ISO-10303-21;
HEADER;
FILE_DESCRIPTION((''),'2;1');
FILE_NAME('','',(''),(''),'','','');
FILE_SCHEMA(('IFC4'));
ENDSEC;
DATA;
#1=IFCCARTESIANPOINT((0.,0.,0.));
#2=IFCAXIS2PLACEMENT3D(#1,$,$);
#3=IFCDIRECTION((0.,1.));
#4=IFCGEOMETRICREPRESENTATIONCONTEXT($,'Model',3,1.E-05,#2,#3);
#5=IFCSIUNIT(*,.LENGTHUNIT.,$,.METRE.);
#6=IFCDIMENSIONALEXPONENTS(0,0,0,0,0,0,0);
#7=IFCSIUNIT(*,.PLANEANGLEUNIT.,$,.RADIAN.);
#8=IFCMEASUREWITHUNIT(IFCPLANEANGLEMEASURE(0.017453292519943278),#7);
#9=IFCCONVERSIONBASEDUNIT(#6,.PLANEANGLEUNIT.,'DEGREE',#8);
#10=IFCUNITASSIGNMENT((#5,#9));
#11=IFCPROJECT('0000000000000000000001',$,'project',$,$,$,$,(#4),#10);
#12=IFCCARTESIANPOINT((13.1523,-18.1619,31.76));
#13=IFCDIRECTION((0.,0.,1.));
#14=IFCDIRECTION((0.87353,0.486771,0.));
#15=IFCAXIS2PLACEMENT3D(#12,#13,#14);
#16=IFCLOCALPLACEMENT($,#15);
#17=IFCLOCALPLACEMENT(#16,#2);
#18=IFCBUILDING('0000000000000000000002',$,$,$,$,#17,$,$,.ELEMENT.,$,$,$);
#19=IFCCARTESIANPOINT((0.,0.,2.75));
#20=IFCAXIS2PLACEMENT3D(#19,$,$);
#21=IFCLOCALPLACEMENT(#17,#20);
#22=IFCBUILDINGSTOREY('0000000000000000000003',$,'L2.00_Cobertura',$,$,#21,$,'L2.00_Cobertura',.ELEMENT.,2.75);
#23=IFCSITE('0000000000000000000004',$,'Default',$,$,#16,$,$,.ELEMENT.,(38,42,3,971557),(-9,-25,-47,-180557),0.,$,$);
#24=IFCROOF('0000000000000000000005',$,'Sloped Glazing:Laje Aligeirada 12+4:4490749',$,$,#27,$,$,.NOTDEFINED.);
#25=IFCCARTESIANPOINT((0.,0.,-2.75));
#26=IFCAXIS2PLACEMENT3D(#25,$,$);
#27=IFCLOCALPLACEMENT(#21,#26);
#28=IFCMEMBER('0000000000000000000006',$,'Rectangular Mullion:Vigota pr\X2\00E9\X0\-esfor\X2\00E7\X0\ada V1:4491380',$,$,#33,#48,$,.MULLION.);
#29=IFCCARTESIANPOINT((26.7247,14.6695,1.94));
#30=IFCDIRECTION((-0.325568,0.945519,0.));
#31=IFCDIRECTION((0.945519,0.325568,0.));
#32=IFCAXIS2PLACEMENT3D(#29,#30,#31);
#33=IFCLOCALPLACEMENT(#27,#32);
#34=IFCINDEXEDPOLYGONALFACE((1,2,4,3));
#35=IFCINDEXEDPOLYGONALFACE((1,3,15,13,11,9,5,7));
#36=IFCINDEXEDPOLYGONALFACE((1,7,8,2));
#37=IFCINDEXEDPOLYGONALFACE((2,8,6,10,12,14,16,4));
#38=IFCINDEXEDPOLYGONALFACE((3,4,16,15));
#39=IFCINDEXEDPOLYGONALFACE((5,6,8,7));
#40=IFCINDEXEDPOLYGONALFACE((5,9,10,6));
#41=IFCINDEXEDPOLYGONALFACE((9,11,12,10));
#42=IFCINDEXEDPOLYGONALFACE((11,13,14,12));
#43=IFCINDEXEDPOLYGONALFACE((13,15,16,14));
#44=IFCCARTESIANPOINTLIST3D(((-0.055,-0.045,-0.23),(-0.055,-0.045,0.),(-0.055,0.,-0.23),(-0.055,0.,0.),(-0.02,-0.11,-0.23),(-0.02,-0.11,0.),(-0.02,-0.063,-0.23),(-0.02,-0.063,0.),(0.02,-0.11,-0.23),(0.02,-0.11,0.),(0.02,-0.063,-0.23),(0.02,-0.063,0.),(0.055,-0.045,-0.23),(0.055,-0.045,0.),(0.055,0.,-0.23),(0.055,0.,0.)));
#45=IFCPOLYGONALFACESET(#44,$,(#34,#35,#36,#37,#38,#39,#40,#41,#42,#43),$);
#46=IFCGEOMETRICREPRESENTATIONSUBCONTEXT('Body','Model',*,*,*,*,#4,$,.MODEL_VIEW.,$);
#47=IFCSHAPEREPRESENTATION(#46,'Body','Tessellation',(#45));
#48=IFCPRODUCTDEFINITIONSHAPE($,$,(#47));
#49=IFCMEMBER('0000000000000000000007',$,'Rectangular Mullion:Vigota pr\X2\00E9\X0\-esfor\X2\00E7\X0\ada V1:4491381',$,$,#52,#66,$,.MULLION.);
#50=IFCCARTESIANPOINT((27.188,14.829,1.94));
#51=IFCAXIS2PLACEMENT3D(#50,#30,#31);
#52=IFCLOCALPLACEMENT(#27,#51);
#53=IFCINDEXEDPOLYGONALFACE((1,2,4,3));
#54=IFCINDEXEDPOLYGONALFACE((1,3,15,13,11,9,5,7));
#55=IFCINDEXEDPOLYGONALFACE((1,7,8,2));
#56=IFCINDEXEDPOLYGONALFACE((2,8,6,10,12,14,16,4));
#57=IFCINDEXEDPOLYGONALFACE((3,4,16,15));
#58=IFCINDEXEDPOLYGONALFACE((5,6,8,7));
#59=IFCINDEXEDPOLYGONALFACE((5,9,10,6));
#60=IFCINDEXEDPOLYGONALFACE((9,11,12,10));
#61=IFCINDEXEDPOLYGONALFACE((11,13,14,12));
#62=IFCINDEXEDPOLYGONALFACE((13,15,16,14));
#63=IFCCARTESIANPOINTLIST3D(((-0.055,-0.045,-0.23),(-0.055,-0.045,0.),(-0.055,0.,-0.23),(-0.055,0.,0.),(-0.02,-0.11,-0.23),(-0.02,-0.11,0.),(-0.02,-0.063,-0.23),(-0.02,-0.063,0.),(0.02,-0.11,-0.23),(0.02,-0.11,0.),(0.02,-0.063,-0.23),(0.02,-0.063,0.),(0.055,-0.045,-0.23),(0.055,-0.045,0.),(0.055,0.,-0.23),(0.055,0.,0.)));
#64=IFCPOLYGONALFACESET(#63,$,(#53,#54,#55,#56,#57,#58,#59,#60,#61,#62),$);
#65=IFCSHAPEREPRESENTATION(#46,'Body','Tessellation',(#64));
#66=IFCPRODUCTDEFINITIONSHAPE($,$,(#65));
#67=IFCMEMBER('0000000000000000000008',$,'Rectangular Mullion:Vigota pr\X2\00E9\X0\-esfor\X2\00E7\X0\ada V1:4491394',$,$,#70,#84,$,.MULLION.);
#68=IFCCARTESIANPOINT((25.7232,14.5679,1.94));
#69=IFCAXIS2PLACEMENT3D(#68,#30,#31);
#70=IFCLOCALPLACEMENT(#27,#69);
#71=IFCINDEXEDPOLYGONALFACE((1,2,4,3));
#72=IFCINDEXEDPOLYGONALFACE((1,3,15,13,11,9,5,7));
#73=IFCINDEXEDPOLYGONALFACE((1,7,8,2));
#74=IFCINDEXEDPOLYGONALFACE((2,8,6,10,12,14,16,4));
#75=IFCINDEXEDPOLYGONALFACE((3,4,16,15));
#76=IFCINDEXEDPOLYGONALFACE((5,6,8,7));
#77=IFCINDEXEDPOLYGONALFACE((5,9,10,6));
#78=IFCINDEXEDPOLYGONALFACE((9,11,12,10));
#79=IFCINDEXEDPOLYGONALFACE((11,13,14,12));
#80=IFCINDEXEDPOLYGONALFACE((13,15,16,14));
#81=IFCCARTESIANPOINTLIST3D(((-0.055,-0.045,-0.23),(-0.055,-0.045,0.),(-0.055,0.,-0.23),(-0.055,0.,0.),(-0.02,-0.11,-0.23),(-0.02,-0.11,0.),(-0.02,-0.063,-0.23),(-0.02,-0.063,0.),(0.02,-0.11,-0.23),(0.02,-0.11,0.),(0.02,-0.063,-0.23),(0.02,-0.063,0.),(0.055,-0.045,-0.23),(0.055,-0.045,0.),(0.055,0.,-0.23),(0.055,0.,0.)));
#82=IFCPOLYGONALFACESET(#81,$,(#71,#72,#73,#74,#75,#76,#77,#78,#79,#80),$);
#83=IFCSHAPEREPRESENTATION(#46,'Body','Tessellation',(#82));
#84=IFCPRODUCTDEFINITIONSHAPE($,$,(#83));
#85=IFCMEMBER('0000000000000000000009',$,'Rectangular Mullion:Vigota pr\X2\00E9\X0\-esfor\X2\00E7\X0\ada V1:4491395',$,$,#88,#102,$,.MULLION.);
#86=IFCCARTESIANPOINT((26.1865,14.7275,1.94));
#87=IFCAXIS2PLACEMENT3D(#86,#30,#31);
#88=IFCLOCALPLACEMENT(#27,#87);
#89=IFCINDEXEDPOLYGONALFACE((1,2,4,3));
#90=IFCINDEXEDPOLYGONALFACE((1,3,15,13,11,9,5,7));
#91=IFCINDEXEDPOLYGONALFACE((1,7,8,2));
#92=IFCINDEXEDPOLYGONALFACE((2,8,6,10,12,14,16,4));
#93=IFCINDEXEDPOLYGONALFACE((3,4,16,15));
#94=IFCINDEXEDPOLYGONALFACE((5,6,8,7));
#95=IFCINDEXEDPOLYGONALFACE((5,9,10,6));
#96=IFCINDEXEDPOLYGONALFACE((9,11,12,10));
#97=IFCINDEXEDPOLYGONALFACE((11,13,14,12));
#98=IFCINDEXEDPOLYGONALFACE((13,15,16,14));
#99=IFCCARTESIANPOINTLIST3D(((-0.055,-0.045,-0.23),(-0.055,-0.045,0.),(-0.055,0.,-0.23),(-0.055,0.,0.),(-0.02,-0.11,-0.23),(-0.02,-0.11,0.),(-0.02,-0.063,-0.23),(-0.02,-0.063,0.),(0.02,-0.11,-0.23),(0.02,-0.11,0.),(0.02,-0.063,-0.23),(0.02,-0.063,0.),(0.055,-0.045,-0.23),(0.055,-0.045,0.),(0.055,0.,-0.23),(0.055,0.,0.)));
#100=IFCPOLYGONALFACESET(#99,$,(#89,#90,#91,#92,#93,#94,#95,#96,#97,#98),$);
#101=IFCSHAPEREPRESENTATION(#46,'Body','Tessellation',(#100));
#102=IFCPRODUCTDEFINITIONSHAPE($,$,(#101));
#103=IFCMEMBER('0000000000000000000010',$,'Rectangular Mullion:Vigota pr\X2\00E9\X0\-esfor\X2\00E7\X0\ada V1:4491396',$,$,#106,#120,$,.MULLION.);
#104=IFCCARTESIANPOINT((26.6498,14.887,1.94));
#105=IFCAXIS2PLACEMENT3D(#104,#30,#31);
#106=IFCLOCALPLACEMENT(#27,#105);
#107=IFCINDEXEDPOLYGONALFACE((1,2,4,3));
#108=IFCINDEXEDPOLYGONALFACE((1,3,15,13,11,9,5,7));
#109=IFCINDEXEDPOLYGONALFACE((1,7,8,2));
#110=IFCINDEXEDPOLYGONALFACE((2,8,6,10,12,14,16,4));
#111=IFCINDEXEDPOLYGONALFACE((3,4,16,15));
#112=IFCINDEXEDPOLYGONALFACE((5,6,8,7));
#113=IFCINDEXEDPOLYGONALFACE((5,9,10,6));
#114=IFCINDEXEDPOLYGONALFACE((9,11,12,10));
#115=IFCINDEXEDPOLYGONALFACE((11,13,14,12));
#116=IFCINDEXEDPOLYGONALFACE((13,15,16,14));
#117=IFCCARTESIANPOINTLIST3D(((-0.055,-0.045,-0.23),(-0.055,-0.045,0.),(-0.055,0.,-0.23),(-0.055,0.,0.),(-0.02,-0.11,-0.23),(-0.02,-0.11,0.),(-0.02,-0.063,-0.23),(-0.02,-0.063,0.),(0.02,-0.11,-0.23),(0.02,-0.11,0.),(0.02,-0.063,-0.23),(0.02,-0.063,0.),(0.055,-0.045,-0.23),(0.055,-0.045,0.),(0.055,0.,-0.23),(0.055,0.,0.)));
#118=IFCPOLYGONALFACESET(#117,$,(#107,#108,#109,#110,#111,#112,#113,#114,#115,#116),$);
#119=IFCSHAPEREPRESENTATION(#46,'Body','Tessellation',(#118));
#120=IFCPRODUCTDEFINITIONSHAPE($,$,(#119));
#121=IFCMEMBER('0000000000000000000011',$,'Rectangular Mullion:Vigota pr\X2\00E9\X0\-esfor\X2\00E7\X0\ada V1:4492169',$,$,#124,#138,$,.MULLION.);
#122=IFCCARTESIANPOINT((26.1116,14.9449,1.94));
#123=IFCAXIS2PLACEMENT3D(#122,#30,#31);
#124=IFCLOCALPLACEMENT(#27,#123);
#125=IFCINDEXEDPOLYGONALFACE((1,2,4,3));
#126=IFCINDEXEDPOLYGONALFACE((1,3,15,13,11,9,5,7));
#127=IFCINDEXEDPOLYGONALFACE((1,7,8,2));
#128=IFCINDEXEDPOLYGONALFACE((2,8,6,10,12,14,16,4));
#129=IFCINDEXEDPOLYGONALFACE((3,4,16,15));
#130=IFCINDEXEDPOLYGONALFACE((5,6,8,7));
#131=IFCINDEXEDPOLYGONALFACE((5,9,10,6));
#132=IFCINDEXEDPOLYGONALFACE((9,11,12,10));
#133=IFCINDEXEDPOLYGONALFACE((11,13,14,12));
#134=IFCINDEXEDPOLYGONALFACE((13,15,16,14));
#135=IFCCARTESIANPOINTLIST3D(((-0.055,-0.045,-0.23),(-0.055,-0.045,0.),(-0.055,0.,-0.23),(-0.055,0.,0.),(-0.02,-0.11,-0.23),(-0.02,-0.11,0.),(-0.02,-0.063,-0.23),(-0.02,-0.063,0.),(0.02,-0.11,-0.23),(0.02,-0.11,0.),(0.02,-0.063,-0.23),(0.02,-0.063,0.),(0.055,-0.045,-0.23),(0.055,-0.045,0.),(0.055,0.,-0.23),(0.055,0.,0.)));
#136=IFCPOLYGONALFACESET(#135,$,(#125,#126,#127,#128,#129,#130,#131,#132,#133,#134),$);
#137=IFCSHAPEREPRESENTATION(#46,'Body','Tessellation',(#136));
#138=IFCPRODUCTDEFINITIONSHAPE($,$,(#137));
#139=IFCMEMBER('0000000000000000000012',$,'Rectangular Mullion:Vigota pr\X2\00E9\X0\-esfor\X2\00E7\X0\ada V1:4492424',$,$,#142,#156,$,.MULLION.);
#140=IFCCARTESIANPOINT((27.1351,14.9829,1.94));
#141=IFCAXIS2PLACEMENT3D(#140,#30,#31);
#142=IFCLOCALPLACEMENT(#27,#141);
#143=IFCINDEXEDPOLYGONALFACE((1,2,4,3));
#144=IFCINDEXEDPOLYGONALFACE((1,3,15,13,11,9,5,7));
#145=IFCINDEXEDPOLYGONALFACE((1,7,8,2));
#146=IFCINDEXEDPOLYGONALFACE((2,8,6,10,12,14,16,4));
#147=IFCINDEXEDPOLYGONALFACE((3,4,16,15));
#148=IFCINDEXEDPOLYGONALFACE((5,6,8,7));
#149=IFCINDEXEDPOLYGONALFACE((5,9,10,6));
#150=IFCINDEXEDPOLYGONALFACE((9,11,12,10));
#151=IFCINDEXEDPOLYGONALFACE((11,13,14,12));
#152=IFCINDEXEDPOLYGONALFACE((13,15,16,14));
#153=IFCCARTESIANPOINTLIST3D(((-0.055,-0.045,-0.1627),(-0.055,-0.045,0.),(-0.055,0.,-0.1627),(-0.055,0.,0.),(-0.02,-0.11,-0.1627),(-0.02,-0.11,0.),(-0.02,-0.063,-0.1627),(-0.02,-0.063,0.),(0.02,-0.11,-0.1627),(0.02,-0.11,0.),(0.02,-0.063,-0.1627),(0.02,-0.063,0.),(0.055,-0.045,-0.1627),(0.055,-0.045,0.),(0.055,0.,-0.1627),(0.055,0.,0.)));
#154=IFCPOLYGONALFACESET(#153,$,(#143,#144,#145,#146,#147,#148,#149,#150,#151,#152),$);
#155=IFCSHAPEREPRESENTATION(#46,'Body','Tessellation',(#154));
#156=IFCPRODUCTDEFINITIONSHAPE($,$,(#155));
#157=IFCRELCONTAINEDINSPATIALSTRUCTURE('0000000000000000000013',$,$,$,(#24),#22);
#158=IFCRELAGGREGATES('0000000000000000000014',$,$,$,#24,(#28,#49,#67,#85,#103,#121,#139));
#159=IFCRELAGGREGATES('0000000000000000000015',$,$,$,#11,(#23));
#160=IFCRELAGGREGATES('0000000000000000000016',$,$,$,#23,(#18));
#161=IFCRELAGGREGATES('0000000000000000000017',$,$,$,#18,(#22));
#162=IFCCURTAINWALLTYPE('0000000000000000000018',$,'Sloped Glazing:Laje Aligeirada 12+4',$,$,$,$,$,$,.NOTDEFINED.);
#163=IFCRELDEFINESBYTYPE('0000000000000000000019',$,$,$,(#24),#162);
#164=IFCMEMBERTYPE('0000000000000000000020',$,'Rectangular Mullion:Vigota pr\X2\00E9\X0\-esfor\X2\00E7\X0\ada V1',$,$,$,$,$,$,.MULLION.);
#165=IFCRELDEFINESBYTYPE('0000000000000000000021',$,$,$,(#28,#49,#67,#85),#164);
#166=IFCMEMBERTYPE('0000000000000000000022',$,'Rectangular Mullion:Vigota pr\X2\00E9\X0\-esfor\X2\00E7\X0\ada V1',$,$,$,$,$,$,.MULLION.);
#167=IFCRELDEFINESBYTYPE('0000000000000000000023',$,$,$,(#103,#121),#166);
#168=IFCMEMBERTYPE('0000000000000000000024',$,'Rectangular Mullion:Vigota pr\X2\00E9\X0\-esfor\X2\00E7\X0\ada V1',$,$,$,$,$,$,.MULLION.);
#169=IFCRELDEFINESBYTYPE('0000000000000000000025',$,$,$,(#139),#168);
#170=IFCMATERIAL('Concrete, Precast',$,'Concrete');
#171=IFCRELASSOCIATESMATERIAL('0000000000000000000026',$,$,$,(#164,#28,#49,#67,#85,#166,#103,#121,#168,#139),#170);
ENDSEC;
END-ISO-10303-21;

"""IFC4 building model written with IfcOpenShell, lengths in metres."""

from ifc_helpers import new_model, entity, si_unit, converted_unit, direction, frame, origin, place, context, subcontext, project, spatial, indexed_curve, outline, extrude, source, transform, mapped, material, type_object, type_shapes, element, aggregate, save


model = new_model("IFC4")

# Units and contexts
model_context = context("Model", 3, precision=1e-05, world=origin(), true_north=direction((0.0, 1.0)))
body_context = subcontext(model_context, "Body", "Model", "MODEL_VIEW")
ifc_project = project(units=[si_unit("LENGTHUNIT", "METRE"), converted_unit("PLANEANGLEUNIT", "DEGREE", entity("IfcPlaneAngleMeasure", 0.017453292519943278), si_unit("PLANEANGLEUNIT", "RADIAN"), dimensions=[0, 0, 0, 0, 0, 0, 0])], contexts=[model_context])

# Site, building, storey
site_placement = place(None, frame((13.1523, -18.1619, 31.76), z_axis=(0.0, 0.0, 1.0), x_axis=(0.87353, 0.486771, 0.0)))
site = spatial("IfcSite", under=ifc_project, at=site_placement, Name="Default", CompositionType="ELEMENT", RefLatitude=(38, 42, 3, 971557), RefLongitude=(-9, -25, -47, -180557), RefElevation=0.0)
building_placement = place(site_placement, origin())
building = spatial("IfcBuilding", under=site, at=building_placement, CompositionType="ELEMENT")
storey_placement = place(building_placement, frame((0.0, 0.0, 2.75)))
storey = spatial("IfcBuildingStorey", under=building, at=storey_placement, Name="L2.00_Cobertura", LongName="L2.00_Cobertura", CompositionType="ELEMENT", Elevation=2.75)

# Roof, members
curtain_wall_type = type_object("IfcCurtainWallType", Name="Sloped Glazing:Laje Aligeirada 12+4", PredefinedType="NOTDEFINED")
roof_placement = place(storey_placement, frame((0.0, 0.0, -2.75)))
roof = element("IfcRoof", 1, at=roof_placement, inside=storey, type_object=curtain_wall_type, Name="Sloped Glazing:Laje Aligeirada 12+4:4490749", PredefinedType="NOTDEFINED")
ifc_material_1 = material(Name="Concrete, Precast", Category="Concrete")
member_type_1 = type_object("IfcMemberType", Name="Rectangular Mullion:Vigota pré-esforçada V1", PredefinedType="MULLION", material=ifc_material_1)
shared_shape_1 = source(origin(), body_context, "Body", "SweptSolid", [
    extrude(outline(indexed_curve([(-0.055, -0.0545), (0.055, -0.0545), (0.055, -0.0095), (0.02, 0.0085), (0.02, 0.0555), (-0.02, 0.0555), (-0.02, 0.0085), (-0.055, -0.0095), (-0.055, -0.0545)], self_intersect=False)), frame((0.0, -0.0545, -0.23), z_axis=(0.0, 0.0, 1.0), x_axis=(-1.0, 0.0, 0.0)), (0.0, 0.0, 1.0), 0.23),
])
type_shapes(member_type_1, [shared_shape_1])
member_1_placement = place(roof_placement, frame((26.7247, 14.6695, 1.94), z_axis=(-0.325568, 0.945519, 0.0), x_axis=(0.945519, 0.325568, 0.0)))
member_1 = element("IfcMember", 2, at=member_1_placement, type_object=member_type_1, material=ifc_material_1, Name="Rectangular Mullion:Vigota pré-esforçada V1:4491380", PredefinedType="MULLION", context=body_context, shape_type="MappedRepresentation", body=[
    mapped(shared_shape_1, transform((0.0, 0.0, 0.0), scale=1.0)),
])
member_2_placement = place(roof_placement, frame((27.188, 14.829, 1.94), z_axis=(-0.325568, 0.945519, 0.0), x_axis=(0.945519, 0.325568, 0.0)))
member_2 = element("IfcMember", 3, at=member_2_placement, type_object=member_type_1, material=ifc_material_1, Name="Rectangular Mullion:Vigota pré-esforçada V1:4491381", PredefinedType="MULLION", context=body_context, shape_type="MappedRepresentation", body=[
    mapped(shared_shape_1, transform((0.0, 0.0, 0.0), scale=1.0)),
])
member_3_placement = place(roof_placement, frame((25.7232, 14.5679, 1.94), z_axis=(-0.325568, 0.945519, 0.0), x_axis=(0.945519, 0.325568, 0.0)))
member_3 = element("IfcMember", 4, at=member_3_placement, type_object=member_type_1, material=ifc_material_1, Name="Rectangular Mullion:Vigota pré-esforçada V1:4491394", PredefinedType="MULLION", context=body_context, shape_type="MappedRepresentation", body=[
    mapped(shared_shape_1, transform((0.0, 0.0, 0.0), scale=1.0)),
])
member_4_placement = place(roof_placement, frame((26.1865, 14.7275, 1.94), z_axis=(-0.325568, 0.945519, 0.0), x_axis=(0.945519, 0.325568, 0.0)))
member_4 = element("IfcMember", 5, at=member_4_placement, type_object=member_type_1, material=ifc_material_1, Name="Rectangular Mullion:Vigota pré-esforçada V1:4491395", PredefinedType="MULLION", context=body_context, shape_type="MappedRepresentation", body=[
    mapped(shared_shape_1, transform((0.0, 0.0, 0.0), scale=1.0)),
])
member_type_2 = type_object("IfcMemberType", Name="Rectangular Mullion:Vigota pré-esforçada V1", PredefinedType="MULLION", material=ifc_material_1)
shared_shape_2 = source(origin(), body_context, "Body", "SweptSolid", [
    extrude(outline(indexed_curve([(-0.055, -0.0545), (0.055, -0.0545), (0.055, -0.0095), (0.02, 0.0085), (0.02, 0.0555), (-0.02, 0.0555), (-0.02, 0.0085), (-0.055, -0.0095), (-0.055, -0.0545)], self_intersect=False)), frame((0.0, -0.0545, -0.23), z_axis=(0.0, 0.0, 1.0), x_axis=(-1.0, 0.0, 0.0)), (0.0, 0.0, 1.0), 0.23),
])
type_shapes(member_type_2, [shared_shape_2])
member_5_placement = place(roof_placement, frame((26.6498, 14.887, 1.94), z_axis=(-0.325568, 0.945519, 0.0), x_axis=(0.945519, 0.325568, 0.0)))
member_5 = element("IfcMember", 6, at=member_5_placement, type_object=member_type_2, material=ifc_material_1, Name="Rectangular Mullion:Vigota pré-esforçada V1:4491396", PredefinedType="MULLION", context=body_context, shape_type="MappedRepresentation", body=[
    mapped(shared_shape_2, transform((0.0, 0.0, 0.0), scale=1.0)),
])
member_6_placement = place(roof_placement, frame((26.1116, 14.9449, 1.94), z_axis=(-0.325568, 0.945519, 0.0), x_axis=(0.945519, 0.325568, 0.0)))
member_6 = element("IfcMember", 7, at=member_6_placement, type_object=member_type_2, material=ifc_material_1, Name="Rectangular Mullion:Vigota pré-esforçada V1:4492169", PredefinedType="MULLION", context=body_context, shape_type="MappedRepresentation", body=[
    mapped(shared_shape_2, transform((0.0, 0.0, 0.0), scale=1.0)),
])
member_type_3 = type_object("IfcMemberType", Name="Rectangular Mullion:Vigota pré-esforçada V1", PredefinedType="MULLION", material=ifc_material_1)
shared_shape_3 = source(origin(), body_context, "Body", "SweptSolid", [
    extrude(outline(indexed_curve([(-0.055, -0.0545), (0.055, -0.0545), (0.055, -0.0095), (0.02, 0.0085), (0.02, 0.0555), (-0.02, 0.0555), (-0.02, 0.0085), (-0.055, -0.0095), (-0.055, -0.0545)], self_intersect=False)), frame((0.0, -0.0545, -0.1627), z_axis=(0.0, 0.0, 1.0), x_axis=(-1.0, 0.0, 0.0)), (0.0, 0.0, 1.0), 0.1627),
])
type_shapes(member_type_3, [shared_shape_3])
member_7_placement = place(roof_placement, frame((27.1351, 14.9829, 1.94), z_axis=(-0.325568, 0.945519, 0.0), x_axis=(0.945519, 0.325568, 0.0)))
member_7 = element("IfcMember", 8, at=member_7_placement, type_object=member_type_3, material=ifc_material_1, Name="Rectangular Mullion:Vigota pré-esforçada V1:4492424", PredefinedType="MULLION", context=body_context, shape_type="MappedRepresentation", body=[
    mapped(shared_shape_3, transform((0.0, 0.0, 0.0), scale=1.0)),
])
aggregate(roof, [member_1, member_2, member_3, member_4, member_5, member_6, member_7])

save(model, "model.ifc")
